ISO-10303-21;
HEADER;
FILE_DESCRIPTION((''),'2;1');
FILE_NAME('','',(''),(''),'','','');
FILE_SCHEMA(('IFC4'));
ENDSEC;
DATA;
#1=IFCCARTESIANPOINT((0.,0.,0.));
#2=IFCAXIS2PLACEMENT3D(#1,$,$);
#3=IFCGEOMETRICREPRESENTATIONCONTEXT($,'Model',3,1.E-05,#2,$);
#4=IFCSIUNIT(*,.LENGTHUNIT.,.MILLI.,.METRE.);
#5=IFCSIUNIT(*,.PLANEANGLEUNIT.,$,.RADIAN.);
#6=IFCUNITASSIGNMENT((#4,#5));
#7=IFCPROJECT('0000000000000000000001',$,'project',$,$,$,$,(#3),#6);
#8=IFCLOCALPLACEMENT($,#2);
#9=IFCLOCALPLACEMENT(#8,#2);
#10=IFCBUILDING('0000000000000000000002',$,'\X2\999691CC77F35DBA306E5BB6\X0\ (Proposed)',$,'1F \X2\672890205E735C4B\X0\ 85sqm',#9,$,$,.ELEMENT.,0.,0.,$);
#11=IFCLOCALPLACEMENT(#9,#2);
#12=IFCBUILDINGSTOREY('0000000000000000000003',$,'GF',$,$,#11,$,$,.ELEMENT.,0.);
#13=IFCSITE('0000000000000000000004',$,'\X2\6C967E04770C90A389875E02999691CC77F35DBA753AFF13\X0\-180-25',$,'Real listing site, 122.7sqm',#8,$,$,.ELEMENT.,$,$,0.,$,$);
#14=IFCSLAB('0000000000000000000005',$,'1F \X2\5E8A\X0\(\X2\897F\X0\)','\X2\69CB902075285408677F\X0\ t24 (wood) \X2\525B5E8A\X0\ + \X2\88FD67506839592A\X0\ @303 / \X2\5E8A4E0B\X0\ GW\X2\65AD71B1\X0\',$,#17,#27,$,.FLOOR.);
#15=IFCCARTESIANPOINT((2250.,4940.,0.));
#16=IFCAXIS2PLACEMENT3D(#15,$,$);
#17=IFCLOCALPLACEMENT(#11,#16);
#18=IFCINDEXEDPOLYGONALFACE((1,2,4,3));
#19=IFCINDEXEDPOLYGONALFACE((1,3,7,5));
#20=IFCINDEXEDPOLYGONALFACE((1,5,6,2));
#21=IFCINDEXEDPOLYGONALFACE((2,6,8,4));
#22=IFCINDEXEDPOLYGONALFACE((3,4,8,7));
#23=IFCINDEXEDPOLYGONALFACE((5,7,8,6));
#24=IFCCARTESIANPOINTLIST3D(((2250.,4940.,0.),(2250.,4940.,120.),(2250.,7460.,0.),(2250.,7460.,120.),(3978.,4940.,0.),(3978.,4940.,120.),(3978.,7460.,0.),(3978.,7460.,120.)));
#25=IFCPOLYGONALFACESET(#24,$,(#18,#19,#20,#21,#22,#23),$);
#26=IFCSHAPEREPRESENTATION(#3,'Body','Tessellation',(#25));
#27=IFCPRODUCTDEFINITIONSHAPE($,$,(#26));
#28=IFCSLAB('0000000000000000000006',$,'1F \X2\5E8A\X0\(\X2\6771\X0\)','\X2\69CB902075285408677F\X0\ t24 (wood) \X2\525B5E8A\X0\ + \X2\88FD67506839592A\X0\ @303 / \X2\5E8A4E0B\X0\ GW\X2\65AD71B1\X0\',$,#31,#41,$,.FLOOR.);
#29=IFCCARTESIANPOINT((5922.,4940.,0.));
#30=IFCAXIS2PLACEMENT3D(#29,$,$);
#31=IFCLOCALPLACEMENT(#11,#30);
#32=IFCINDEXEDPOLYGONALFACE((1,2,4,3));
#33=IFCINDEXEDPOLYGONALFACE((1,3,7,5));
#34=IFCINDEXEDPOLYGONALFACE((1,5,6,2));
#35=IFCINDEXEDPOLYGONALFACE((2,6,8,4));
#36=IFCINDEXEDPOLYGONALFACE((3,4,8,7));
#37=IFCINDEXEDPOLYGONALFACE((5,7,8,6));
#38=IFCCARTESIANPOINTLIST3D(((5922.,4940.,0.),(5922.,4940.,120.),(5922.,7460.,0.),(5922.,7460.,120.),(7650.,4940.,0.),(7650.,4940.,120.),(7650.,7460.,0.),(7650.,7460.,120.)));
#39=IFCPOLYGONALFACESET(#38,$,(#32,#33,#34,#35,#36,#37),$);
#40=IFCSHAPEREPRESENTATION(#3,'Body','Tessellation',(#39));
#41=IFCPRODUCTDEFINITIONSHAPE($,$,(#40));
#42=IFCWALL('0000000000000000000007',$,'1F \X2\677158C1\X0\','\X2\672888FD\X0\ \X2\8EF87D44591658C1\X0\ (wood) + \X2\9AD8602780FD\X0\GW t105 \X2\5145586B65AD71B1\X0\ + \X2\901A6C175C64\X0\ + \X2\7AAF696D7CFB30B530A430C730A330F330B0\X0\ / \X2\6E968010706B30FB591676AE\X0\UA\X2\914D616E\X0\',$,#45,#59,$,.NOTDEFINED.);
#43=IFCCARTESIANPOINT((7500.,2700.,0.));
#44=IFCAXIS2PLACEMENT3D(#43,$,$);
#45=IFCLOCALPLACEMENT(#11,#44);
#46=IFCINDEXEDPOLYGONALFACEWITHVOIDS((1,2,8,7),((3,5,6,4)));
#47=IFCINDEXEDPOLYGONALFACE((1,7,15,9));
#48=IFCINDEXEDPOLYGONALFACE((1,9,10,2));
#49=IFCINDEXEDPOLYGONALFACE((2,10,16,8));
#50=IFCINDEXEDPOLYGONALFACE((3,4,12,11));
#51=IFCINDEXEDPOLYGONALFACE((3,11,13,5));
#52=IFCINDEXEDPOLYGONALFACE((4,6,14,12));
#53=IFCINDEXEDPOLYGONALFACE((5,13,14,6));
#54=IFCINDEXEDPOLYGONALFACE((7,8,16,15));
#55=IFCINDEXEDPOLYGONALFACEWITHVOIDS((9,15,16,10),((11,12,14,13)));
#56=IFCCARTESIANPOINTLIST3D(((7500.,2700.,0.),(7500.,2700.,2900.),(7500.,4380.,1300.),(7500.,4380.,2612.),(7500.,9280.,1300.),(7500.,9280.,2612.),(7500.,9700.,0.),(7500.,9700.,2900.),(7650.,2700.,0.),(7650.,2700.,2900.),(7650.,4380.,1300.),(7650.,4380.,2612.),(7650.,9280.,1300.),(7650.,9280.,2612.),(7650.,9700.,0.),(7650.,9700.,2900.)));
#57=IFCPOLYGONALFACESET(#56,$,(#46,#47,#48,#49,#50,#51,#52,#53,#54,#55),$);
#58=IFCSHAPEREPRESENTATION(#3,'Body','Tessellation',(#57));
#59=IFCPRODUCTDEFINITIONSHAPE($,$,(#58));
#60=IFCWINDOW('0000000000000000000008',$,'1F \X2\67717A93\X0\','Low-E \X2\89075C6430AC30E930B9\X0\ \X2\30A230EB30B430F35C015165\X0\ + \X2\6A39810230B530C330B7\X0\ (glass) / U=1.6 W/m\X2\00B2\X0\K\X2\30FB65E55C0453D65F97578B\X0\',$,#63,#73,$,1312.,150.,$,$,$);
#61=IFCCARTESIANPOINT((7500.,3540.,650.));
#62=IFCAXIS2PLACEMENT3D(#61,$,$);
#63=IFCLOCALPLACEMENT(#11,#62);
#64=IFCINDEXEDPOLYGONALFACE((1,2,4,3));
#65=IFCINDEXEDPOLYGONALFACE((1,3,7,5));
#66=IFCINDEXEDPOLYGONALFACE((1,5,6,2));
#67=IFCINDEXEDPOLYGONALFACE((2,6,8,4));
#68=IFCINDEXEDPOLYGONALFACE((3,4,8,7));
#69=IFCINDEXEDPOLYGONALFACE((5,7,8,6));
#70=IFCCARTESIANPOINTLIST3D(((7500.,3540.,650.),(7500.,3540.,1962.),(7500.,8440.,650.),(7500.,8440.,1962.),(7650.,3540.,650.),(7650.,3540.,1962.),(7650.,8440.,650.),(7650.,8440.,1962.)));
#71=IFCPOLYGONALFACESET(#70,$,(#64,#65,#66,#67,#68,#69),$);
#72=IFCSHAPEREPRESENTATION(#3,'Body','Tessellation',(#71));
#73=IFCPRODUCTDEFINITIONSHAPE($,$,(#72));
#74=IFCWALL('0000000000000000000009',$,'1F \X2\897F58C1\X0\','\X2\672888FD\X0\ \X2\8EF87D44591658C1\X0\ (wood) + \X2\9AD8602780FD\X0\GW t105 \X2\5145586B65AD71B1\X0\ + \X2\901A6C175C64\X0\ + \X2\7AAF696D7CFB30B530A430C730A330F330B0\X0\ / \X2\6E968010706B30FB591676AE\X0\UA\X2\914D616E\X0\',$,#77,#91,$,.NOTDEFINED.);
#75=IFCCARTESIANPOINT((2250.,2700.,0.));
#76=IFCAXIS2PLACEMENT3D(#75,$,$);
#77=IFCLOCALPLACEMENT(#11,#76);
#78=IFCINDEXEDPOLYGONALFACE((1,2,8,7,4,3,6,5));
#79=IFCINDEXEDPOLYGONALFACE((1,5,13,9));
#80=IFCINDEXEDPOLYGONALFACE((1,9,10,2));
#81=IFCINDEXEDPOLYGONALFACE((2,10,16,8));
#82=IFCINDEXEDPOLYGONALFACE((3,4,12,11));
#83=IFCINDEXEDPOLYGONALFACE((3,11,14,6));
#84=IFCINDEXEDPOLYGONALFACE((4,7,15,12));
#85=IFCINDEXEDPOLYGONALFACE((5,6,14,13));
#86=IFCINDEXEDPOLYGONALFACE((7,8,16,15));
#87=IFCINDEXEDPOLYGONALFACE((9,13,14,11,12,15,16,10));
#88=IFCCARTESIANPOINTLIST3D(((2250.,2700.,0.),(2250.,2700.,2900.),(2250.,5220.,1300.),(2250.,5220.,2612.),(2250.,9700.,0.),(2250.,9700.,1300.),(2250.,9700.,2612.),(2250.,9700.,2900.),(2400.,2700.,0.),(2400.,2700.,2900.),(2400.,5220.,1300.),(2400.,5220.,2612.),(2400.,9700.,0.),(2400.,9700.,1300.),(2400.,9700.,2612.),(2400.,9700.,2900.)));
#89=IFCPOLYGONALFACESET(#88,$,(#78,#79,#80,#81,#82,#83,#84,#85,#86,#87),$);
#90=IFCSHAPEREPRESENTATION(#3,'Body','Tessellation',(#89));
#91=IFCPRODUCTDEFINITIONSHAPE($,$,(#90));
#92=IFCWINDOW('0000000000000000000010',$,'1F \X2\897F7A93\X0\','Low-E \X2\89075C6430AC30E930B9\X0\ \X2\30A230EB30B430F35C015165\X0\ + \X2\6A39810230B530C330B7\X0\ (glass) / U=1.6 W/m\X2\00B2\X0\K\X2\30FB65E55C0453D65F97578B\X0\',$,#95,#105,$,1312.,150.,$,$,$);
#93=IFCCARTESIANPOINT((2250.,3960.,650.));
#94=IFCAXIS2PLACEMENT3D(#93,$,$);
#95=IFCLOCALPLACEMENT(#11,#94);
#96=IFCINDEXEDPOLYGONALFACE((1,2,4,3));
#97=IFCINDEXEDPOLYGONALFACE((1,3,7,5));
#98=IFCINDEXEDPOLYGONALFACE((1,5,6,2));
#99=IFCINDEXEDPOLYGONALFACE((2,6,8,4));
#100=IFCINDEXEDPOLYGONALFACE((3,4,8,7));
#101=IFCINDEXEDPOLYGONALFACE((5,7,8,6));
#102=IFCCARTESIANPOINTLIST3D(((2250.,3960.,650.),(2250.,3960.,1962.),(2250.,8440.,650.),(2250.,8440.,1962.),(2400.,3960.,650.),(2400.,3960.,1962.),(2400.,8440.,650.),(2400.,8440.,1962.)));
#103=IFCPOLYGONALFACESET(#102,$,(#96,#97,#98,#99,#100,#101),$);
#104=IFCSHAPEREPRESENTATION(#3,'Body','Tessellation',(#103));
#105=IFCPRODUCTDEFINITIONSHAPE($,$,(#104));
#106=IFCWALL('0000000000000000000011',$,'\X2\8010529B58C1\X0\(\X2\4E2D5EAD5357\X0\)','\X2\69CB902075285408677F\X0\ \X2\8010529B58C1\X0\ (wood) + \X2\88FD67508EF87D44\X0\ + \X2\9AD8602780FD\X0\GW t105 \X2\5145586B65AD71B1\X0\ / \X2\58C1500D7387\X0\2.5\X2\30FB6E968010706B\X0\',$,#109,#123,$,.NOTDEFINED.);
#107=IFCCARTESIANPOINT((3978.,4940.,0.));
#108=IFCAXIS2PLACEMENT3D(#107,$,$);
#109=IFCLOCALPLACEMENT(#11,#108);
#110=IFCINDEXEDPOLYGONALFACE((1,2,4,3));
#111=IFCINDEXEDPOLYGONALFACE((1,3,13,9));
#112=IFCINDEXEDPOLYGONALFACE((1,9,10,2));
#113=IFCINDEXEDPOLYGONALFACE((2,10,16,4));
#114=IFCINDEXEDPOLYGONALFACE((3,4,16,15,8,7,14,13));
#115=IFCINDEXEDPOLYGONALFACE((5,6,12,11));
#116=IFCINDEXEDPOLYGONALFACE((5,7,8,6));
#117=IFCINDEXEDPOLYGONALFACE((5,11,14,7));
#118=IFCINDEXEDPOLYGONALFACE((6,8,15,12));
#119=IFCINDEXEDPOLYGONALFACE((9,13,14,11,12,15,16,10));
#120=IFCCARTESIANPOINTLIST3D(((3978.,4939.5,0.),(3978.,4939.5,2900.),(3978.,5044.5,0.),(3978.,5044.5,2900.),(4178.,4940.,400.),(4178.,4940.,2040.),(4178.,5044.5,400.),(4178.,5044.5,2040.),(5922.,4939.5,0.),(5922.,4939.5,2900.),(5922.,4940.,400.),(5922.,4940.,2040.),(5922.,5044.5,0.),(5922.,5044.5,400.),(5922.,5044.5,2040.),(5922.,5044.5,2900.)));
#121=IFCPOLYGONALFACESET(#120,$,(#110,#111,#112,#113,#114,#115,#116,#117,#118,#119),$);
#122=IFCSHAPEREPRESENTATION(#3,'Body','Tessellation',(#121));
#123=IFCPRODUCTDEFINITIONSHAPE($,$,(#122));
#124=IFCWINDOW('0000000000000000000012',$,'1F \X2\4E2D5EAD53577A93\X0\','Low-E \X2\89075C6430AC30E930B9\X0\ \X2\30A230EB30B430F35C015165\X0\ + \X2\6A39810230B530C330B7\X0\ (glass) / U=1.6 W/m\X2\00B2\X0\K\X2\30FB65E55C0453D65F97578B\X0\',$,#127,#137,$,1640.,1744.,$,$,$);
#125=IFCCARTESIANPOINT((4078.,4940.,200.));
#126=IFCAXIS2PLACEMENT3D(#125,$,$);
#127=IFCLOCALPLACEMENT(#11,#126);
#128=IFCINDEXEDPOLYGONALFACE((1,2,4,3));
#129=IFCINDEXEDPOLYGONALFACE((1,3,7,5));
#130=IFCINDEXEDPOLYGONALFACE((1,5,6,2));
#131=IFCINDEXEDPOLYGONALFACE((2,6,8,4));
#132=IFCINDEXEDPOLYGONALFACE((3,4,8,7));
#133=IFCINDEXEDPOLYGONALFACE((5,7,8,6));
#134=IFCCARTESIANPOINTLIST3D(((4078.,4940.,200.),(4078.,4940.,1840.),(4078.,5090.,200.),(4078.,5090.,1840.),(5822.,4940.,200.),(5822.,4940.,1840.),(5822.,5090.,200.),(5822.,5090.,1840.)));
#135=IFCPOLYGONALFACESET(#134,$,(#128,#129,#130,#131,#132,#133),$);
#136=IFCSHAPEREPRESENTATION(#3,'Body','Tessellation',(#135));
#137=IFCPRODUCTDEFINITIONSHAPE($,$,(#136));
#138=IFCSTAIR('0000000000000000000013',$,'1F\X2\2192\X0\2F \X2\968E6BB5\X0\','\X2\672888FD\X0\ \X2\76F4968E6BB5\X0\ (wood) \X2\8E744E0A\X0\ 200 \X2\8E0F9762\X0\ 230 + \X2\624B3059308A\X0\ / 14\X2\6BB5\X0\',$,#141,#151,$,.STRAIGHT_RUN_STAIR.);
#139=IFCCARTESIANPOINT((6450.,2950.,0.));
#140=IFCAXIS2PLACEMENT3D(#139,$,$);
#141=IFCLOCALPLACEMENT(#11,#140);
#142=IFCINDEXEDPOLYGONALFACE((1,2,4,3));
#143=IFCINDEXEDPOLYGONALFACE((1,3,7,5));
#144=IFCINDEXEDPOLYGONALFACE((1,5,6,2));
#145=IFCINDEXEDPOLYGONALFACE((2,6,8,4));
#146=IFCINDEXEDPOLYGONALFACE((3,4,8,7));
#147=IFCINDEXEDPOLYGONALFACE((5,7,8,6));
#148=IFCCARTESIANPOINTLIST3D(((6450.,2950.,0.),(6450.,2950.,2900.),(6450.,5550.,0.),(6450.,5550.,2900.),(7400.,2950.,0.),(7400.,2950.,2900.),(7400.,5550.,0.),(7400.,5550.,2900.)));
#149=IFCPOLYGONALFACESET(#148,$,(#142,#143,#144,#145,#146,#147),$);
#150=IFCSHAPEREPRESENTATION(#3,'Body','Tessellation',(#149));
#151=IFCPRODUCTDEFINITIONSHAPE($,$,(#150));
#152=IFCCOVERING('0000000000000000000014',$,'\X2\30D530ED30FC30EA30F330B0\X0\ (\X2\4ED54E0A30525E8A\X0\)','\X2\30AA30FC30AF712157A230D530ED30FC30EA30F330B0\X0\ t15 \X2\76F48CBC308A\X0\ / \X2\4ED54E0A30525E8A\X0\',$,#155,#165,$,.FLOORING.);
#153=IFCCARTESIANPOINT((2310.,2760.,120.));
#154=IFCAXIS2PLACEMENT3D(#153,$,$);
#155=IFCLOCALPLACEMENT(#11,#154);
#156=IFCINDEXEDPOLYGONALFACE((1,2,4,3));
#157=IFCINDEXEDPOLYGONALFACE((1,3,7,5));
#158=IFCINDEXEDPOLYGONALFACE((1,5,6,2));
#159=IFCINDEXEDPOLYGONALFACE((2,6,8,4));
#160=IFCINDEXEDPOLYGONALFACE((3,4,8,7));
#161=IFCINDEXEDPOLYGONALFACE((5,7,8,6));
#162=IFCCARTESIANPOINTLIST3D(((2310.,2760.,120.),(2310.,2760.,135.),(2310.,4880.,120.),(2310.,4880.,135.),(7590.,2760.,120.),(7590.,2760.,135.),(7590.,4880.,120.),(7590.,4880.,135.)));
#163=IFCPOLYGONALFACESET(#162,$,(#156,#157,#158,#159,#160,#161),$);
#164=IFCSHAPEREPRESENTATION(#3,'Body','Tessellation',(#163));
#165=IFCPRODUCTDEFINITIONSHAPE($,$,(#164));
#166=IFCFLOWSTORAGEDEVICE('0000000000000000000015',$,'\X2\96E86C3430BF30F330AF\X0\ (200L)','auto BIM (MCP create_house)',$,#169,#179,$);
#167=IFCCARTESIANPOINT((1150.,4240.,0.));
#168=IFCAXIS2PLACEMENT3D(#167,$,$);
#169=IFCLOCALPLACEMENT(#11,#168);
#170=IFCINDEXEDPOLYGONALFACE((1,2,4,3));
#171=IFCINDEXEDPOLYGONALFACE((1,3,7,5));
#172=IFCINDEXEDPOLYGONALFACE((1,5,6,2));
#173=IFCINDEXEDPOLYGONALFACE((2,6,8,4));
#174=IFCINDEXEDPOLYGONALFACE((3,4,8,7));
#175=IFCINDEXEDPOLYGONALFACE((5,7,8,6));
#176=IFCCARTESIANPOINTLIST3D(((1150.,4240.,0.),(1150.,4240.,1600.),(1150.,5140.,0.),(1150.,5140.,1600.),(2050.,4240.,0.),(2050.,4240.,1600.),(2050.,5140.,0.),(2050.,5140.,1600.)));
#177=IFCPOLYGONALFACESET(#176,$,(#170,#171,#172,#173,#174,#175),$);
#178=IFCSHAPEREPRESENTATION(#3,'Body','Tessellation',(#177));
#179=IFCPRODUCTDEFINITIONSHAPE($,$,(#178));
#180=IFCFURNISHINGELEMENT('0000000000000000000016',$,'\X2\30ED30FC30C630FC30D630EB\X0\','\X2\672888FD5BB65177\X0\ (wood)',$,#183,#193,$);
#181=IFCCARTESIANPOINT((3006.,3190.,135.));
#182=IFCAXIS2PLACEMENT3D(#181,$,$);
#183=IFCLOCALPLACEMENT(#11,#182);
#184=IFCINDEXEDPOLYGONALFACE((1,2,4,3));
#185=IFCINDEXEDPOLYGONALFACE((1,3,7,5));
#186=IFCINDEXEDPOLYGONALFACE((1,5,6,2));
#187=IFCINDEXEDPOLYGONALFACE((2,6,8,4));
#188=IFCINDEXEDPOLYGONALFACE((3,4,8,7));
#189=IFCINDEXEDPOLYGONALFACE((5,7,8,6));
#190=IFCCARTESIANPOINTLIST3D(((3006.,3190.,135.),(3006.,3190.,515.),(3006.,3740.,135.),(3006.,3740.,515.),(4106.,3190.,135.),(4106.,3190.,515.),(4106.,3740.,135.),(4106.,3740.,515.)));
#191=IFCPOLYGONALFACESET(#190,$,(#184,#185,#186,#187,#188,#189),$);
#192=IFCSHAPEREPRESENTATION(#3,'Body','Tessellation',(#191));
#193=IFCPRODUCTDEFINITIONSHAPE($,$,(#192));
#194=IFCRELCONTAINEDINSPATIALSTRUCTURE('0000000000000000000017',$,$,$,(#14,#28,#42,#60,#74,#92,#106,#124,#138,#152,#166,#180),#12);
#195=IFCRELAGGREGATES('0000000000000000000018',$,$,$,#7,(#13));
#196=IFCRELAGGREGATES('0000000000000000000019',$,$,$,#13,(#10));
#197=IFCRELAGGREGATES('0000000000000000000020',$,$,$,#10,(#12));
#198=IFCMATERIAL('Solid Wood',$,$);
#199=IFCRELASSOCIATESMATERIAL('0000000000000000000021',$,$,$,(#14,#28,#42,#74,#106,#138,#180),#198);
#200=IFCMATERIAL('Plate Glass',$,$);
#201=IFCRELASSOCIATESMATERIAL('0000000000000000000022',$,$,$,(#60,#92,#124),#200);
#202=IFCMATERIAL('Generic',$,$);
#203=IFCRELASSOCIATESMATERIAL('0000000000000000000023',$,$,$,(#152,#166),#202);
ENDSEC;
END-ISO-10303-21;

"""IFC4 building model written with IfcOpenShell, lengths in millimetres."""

from ifc_helpers import new_model, si_unit, frame, frame_2d, origin, place, context, project, spatial, rectangle, extrude, material, element, fill, save


model = new_model("IFC4")

# Units and contexts
model_context = context("Model", 3, precision=1e-05, world=origin())
ifc_project = project(units=[si_unit("LENGTHUNIT", "METRE", prefix="MILLI"), si_unit("PLANEANGLEUNIT", "RADIAN")], contexts=[model_context])

# Site, building, storey
site_placement = place(None, origin())
site = spatial("IfcSite", under=ifc_project, at=site_placement, Name="沖縄県那覇市首里石嶺町３-180-25", ObjectType="Real listing site, 122.7sqm", CompositionType="ELEMENT", RefElevation=0.0)
building_placement = place(site_placement, origin())
building = spatial("IfcBuilding", under=site, at=building_placement, Name="首里石嶺の家 (Proposed)", ObjectType="1F 木造平屋 85sqm", CompositionType="ELEMENT", ElevationOfRefHeight=0.0, ElevationOfTerrain=0.0)
storey_placement = place(building_placement, origin())
storey = spatial("IfcBuildingStorey", under=building, at=storey_placement, Name="GF", CompositionType="ELEMENT", Elevation=0.0)

# Slabs
ifc_material_1 = material(Name="Solid Wood")
slab_1_placement = place(storey_placement, frame((2250.0, 4940.0, 0.0)))
element("IfcSlab", 1, at=slab_1_placement, inside=storey, material=ifc_material_1, Name="1F 床(西)", Description="構造用合板 t24 (wood) 剛床 + 製材根太 @303 / 床下 GW断熱", PredefinedType="FLOOR", context=model_context, shape_type="SweptSolid", body=[
    extrude(rectangle(XDim=1728.0, YDim=2520.0, at=frame_2d((864.0, 1260.0))), frame((2250.0, 4940.0, 0.0)), (0.0, 0.0, 1.0), 120.0),
])
slab_2_placement = place(storey_placement, frame((5922.0, 4940.0, 0.0)))
element("IfcSlab", 2, at=slab_2_placement, inside=storey, material=ifc_material_1, Name="1F 床(東)", Description="構造用合板 t24 (wood) 剛床 + 製材根太 @303 / 床下 GW断熱", PredefinedType="FLOOR", context=model_context, shape_type="SweptSolid", body=[
    extrude(rectangle(XDim=1728.0, YDim=2520.0, at=frame_2d((864.0, 1260.0))), frame((5922.0, 4940.0, 0.0)), (0.0, 0.0, 1.0), 120.0),
])

# Shared definitions
ifc_material_2 = material(Name="Plate Glass")

# Walls, openings, windows
wall_1_placement = place(storey_placement, frame((7500.0, 2700.0, 0.0)))
wall_1 = element("IfcWall", 3, at=wall_1_placement, inside=storey, material=ifc_material_1, Name="1F 東壁", Description="木製 軸組外壁 (wood) + 高性能GW t105 充填断熱 + 通気層 + 窯業系サイディング / 準耐火・外皮UA配慮", PredefinedType="NOTDEFINED", context=model_context, shape_type="SweptSolid", body=[
    extrude(rectangle(XDim=150.0, YDim=7000.0, at=frame_2d((75.0, 3500.0))), frame((7500.0, 2700.0, 0.0)), (0.0, 0.0, 1.0), 2900.0),
])
opening_1_placement = place(storey_placement, frame((7500.0, 3540.0, 650.0)))
opening_1 = element("IfcOpeningElement", 4, at=opening_1_placement, cuts=wall_1, PredefinedType="NOTDEFINED", context=model_context, shape_type="SweptSolid", body=[
    extrude(rectangle(XDim=150.0, YDim=4900.0, at=frame_2d((75.0, 2450.0))), frame((7500.0, 3540.0, 650.0)), (0.0, 0.0, 1.0), 1312.0),
])
window_1_placement = place(storey_placement, frame((7500.0, 3540.0, 650.0)))
window_1 = element("IfcWindow", 5, at=window_1_placement, inside=storey, material=ifc_material_2, Name="1F 東窓", Description="Low-E 複層ガラス アルゴン封入 + 樹脂サッシ (glass) / U=1.6 W/m²K・日射取得型", OverallHeight=1312.0, OverallWidth=150.0, context=model_context, shape_type="SweptSolid", body=[
    extrude(rectangle(XDim=150.0, YDim=4900.0, at=frame_2d((75.0, 2450.0))), frame((7500.0, 3540.0, 650.0)), (0.0, 0.0, 1.0), 1312.0),
])
fill(opening_1, window_1)
wall_2_placement = place(storey_placement, frame((2250.0, 2700.0, 0.0)))
wall_2 = element("IfcWall", 6, at=wall_2_placement, inside=storey, material=ifc_material_1, Name="1F 西壁", Description="木製 軸組外壁 (wood) + 高性能GW t105 充填断熱 + 通気層 + 窯業系サイディング / 準耐火・外皮UA配慮", PredefinedType="NOTDEFINED", context=model_context, shape_type="SweptSolid", body=[
    extrude(rectangle(XDim=150.0, YDim=7000.0, at=frame_2d((75.0, 3500.0))), frame((2250.0, 2700.0, 0.0)), (0.0, 0.0, 1.0), 2900.0),
])
opening_2_placement = place(storey_placement, frame((2250.0, 3960.0, 650.0)))
opening_2 = element("IfcOpeningElement", 7, at=opening_2_placement, cuts=wall_2, PredefinedType="NOTDEFINED", context=model_context, shape_type="SweptSolid", body=[
    extrude(rectangle(XDim=150.0, YDim=4480.0, at=frame_2d((75.0, 2240.0))), frame((2250.0, 3960.0, 650.0)), (0.0, 0.0, 1.0), 1312.0),
])
window_2_placement = place(storey_placement, frame((2250.0, 3960.0, 650.0)))
window_2 = element("IfcWindow", 8, at=window_2_placement, inside=storey, material=ifc_material_2, Name="1F 西窓", Description="Low-E 複層ガラス アルゴン封入 + 樹脂サッシ (glass) / U=1.6 W/m²K・日射取得型", OverallHeight=1312.0, OverallWidth=150.0, context=model_context, shape_type="SweptSolid", body=[
    extrude(rectangle(XDim=150.0, YDim=4480.0, at=frame_2d((75.0, 2240.0))), frame((2250.0, 3960.0, 650.0)), (0.0, 0.0, 1.0), 1312.0),
])
fill(opening_2, window_2)
wall_3_placement = place(storey_placement, frame((3978.0, 4940.0, 0.0)))
wall_3 = element("IfcWall", 9, at=wall_3_placement, inside=storey, material=ifc_material_1, Name="耐力壁(中庭南)", Description="構造用合板 耐力壁 (wood) + 製材軸組 + 高性能GW t105 充填断熱 / 壁倍率2.5・準耐火", PredefinedType="NOTDEFINED", context=model_context, shape_type="SweptSolid", body=[
    extrude(rectangle(XDim=1944.0, YDim=105.0, at=frame_2d((972.0, 52.0))), frame((3978.0, 4940.0, 0.0)), (0.0, 0.0, 1.0), 2900.0),
])
opening_3_placement = place(storey_placement, frame((4078.0, 4940.0, 200.0)))
opening_3 = element("IfcOpeningElement", 10, at=opening_3_placement, cuts=wall_3, PredefinedType="NOTDEFINED", context=model_context, shape_type="SweptSolid", body=[
    extrude(rectangle(XDim=1744.0, YDim=150.0, at=frame_2d((872.0, 75.0))), frame((4078.0, 4940.0, 200.0)), (0.0, 0.0, 1.0), 1640.0),
])
window_3_placement = place(storey_placement, frame((4078.0, 4940.0, 200.0)))
window_3 = element("IfcWindow", 11, at=window_3_placement, inside=storey, material=ifc_material_2, Name="1F 中庭南窓", Description="Low-E 複層ガラス アルゴン封入 + 樹脂サッシ (glass) / U=1.6 W/m²K・日射取得型", OverallHeight=1640.0, OverallWidth=1744.0, context=model_context, shape_type="SweptSolid", body=[
    extrude(rectangle(XDim=1744.0, YDim=150.0, at=frame_2d((872.0, 75.0))), frame((4078.0, 4940.0, 200.0)), (0.0, 0.0, 1.0), 1640.0),
])
fill(opening_3, window_3)

# Stair
stair_placement = place(storey_placement, frame((6450.0, 2950.0, 0.0)))
element("IfcStair", 12, at=stair_placement, inside=storey, material=ifc_material_1, Name="1F→2F 階段", Description="木製 直階段 (wood) 蹴上 200 踏面 230 + 手すり / 14段", PredefinedType="STRAIGHT_RUN_STAIR", context=model_context, shape_type="SweptSolid", body=[
    extrude(rectangle(XDim=950.0, YDim=2600.0, at=frame_2d((475.0, 1300.0))), frame((6450.0, 2950.0, 0.0)), (0.0, 0.0, 1.0), 2900.0),
])

# Covering
ifc_material_3 = material(Name="Generic")
covering_placement = place(storey_placement, frame((2310.0, 2760.0, 120.0)))
element("IfcCovering", 13, at=covering_placement, inside=storey, material=ifc_material_3, Name="フローリング (仕上げ床)", Description="オーク無垢フローリング t15 直貼り / 仕上げ床", PredefinedType="FLOORING", context=model_context, shape_type="SweptSolid", body=[
    extrude(rectangle(XDim=5280.0, YDim=2120.0, at=frame_2d((2640.0, 1060.0))), frame((2310.0, 2760.0, 120.0)), (0.0, 0.0, 1.0), 15.0),
])

# Flow storage device
flow_storage_device_placement = place(storey_placement, frame((1150.0, 4240.0, 0.0)))
element("IfcFlowStorageDevice", 14, at=flow_storage_device_placement, inside=storey, material=ifc_material_3, Name="雨水タンク (200L)", Description="auto BIM (MCP create_house)", context=model_context, shape_type="SweptSolid", body=[
    extrude(rectangle(XDim=900.0, YDim=900.0, at=frame_2d((450.0, 450.0))), frame((1150.0, 4240.0, 0.0)), (0.0, 0.0, 1.0), 1600.0),
])

# Furnishing element
furnishing_1_placement = place(storey_placement, frame((3006.0, 3190.0, 135.0)))
element("IfcFurnishingElement", 15, at=furnishing_1_placement, inside=storey, material=ifc_material_1, Name="ローテーブル", Description="木製家具 (wood)", context=model_context, shape_type="SweptSolid", body=[
    extrude(rectangle(XDim=1100.0, YDim=550.0, at=frame_2d((550.0, 275.0))), frame((3006.0, 3190.0, 135.0)), (0.0, 0.0, 1.0), 380.0),
])

save(model, "model.ifc")
